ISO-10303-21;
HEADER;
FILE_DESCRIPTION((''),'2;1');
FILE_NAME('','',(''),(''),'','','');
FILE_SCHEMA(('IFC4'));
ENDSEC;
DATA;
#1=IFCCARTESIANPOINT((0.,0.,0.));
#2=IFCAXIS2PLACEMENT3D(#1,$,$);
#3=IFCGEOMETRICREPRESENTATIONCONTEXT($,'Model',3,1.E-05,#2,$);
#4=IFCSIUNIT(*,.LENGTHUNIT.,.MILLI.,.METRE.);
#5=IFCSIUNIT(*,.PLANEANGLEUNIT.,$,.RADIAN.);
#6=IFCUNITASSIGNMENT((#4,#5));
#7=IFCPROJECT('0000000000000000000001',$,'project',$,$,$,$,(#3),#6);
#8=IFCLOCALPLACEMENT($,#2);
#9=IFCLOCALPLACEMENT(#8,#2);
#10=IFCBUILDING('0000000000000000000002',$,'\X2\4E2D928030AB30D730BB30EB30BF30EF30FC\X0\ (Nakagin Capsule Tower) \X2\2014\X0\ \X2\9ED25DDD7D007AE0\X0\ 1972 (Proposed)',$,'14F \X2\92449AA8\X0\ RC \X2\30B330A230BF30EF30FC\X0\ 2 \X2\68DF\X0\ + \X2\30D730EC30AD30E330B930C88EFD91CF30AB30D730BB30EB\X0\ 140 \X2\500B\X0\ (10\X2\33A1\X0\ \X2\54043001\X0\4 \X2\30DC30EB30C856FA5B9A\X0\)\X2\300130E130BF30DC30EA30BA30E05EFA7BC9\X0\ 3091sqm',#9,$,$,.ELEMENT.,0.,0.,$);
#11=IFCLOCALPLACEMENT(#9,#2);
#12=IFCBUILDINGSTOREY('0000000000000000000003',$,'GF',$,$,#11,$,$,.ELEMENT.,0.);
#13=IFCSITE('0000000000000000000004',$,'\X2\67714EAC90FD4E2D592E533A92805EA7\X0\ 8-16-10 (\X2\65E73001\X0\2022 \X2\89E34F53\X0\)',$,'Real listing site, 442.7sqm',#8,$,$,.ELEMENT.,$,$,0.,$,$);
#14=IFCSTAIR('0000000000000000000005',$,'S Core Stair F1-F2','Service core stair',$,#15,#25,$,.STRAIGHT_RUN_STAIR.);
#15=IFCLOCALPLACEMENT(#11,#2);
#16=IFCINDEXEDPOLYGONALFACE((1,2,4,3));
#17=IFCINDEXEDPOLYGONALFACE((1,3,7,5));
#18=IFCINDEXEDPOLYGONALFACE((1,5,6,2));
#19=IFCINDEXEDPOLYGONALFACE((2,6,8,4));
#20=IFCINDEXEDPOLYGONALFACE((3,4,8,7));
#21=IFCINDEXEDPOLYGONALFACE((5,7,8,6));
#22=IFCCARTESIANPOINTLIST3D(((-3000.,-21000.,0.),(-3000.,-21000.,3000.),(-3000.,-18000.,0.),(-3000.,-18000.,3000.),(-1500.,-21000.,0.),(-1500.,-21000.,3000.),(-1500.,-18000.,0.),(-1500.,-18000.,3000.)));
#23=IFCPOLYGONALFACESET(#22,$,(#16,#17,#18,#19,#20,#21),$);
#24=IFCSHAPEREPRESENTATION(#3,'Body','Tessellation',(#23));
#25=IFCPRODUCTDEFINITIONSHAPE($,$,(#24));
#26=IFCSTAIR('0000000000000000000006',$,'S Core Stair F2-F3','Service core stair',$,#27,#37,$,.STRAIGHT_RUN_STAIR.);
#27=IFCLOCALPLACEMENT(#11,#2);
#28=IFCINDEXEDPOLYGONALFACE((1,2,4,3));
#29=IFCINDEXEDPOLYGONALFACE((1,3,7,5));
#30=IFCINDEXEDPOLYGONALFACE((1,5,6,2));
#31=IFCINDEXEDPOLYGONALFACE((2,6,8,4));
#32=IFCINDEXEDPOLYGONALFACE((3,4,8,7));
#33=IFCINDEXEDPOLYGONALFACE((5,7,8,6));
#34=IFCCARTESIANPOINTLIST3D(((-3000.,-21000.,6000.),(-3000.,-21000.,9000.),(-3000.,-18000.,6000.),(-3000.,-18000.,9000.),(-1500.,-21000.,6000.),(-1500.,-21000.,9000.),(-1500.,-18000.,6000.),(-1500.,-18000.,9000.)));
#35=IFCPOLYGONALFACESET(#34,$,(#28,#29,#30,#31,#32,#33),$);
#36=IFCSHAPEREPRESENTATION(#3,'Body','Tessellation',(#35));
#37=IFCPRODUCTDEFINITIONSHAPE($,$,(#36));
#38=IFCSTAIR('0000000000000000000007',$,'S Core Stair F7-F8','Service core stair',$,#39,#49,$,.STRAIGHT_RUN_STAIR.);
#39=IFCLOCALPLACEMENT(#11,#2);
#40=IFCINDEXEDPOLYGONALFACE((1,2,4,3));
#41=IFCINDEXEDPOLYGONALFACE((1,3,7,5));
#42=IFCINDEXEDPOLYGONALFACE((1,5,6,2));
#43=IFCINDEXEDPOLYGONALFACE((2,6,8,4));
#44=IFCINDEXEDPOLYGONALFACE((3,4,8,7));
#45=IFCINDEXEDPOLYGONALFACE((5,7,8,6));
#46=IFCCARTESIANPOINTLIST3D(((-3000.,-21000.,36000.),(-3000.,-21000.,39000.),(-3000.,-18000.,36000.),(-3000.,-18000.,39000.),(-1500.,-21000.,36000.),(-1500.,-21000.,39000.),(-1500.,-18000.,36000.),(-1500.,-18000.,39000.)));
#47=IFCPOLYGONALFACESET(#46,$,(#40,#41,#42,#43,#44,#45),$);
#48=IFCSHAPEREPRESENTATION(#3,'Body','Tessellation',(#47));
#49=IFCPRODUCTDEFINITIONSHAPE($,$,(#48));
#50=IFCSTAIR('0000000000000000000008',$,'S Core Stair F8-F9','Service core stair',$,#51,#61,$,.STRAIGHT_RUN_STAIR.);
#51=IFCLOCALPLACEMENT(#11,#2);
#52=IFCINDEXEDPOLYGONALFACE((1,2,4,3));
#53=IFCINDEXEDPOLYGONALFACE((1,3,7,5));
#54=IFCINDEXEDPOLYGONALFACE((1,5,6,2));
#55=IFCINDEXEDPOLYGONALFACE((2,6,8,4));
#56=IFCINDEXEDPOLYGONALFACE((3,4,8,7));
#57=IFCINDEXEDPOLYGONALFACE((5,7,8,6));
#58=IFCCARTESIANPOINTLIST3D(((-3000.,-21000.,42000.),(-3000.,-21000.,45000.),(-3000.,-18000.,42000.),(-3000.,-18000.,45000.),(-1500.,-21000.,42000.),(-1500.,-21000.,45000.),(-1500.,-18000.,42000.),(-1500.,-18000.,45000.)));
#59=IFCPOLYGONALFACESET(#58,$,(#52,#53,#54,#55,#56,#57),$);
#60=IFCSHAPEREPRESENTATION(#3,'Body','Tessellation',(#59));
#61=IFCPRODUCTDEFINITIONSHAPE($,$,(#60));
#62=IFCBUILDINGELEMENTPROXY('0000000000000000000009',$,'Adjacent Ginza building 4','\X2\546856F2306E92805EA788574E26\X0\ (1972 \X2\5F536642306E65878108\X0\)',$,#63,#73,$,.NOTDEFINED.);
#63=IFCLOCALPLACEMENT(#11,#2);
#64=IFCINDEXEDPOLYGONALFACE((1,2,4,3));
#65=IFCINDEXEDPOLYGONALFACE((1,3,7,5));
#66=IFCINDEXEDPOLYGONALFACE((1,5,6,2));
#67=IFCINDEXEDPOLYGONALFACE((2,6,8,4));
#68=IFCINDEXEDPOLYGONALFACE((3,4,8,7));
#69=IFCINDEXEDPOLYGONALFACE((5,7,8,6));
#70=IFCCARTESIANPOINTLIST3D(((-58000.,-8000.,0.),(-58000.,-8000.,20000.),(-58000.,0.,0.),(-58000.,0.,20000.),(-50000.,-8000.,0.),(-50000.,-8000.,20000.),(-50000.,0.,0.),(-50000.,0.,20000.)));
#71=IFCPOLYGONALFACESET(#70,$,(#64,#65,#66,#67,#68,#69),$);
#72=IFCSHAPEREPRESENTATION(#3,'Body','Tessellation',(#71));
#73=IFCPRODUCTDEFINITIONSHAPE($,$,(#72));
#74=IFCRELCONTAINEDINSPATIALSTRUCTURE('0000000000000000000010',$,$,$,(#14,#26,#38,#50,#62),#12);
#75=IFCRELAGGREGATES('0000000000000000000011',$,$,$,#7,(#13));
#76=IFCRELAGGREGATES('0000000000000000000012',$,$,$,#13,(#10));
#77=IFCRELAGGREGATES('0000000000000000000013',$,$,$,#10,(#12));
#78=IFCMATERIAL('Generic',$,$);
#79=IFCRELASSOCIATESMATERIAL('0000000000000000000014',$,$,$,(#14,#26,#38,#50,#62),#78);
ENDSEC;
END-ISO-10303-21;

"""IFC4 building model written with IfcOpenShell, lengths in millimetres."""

from ifc_helpers import new_model, si_unit, frame, frame_2d, origin, place, context, project, spatial, rectangle, extrude, material, element, save


model = new_model("IFC4")

# Units and contexts
model_context = context("Model", 3, precision=1e-05, world=origin())
ifc_project = project(units=[si_unit("LENGTHUNIT", "METRE", prefix="MILLI"), si_unit("PLANEANGLEUNIT", "RADIAN")], contexts=[model_context])

# Site, building, storey
site_placement = place(None, origin())
site = spatial("IfcSite", under=ifc_project, at=site_placement, Name="東京都中央区銀座 8-16-10 (旧、2022 解体)", ObjectType="Real listing site, 442.7sqm", CompositionType="ELEMENT", RefElevation=0.0)
building_placement = place(site_placement, origin())
building = spatial("IfcBuilding", under=site, at=building_placement, Name="中銀カプセルタワー (Nakagin Capsule Tower) — 黒川紀章 1972 (Proposed)", ObjectType="14F 鉄骨 RC コアタワー 2 棟 + プレキャスト軽量カプセル 140 個 (10㎡ 各、4 ボルト固定)、メタボリズム建築 3091sqm", CompositionType="ELEMENT", ElevationOfRefHeight=0.0, ElevationOfTerrain=0.0)
storey_placement = place(building_placement, origin())
storey = spatial("IfcBuildingStorey", under=building, at=storey_placement, Name="GF", CompositionType="ELEMENT", Elevation=0.0)

# Stairs
ifc_material_1 = material(Name="Generic")
stair_1_placement = place(storey_placement, frame((-1500.0, -10500.0, 0.0)))
element("IfcStair", 1, at=stair_1_placement, inside=storey, material=ifc_material_1, Name="S Core Stair F1-F2", Description="Service core stair", PredefinedType="STRAIGHT_RUN_STAIR", context=model_context, shape_type="SweptSolid", body=[
    extrude(rectangle(XDim=1500.0, YDim=3000.0, at=frame_2d((750.0, 1500.0))), frame((-1500.0, -10500.0, 0.0)), (0.0, 0.0, 1.0), 3000.0),
])
stair_2_placement = place(storey_placement, frame((-1500.0, -10500.0, 3000.0)))
element("IfcStair", 2, at=stair_2_placement, inside=storey, material=ifc_material_1, Name="S Core Stair F2-F3", Description="Service core stair", PredefinedType="STRAIGHT_RUN_STAIR", context=model_context, shape_type="SweptSolid", body=[
    extrude(rectangle(XDim=1500.0, YDim=3000.0, at=frame_2d((750.0, 1500.0))), frame((-1500.0, -10500.0, 3000.0)), (0.0, 0.0, 1.0), 3000.0),
])
stair_3_placement = place(storey_placement, frame((-1500.0, -10500.0, 18000.0)))
element("IfcStair", 3, at=stair_3_placement, inside=storey, material=ifc_material_1, Name="S Core Stair F7-F8", Description="Service core stair", PredefinedType="STRAIGHT_RUN_STAIR", context=model_context, shape_type="SweptSolid", body=[
    extrude(rectangle(XDim=1500.0, YDim=3000.0, at=frame_2d((750.0, 1500.0))), frame((-1500.0, -10500.0, 18000.0)), (0.0, 0.0, 1.0), 3000.0),
])
stair_4_placement = place(storey_placement, frame((-1500.0, -10500.0, 21000.0)))
element("IfcStair", 4, at=stair_4_placement, inside=storey, material=ifc_material_1, Name="S Core Stair F8-F9", Description="Service core stair", PredefinedType="STRAIGHT_RUN_STAIR", context=model_context, shape_type="SweptSolid", body=[
    extrude(rectangle(XDim=1500.0, YDim=3000.0, at=frame_2d((750.0, 1500.0))), frame((-1500.0, -10500.0, 21000.0)), (0.0, 0.0, 1.0), 3000.0),
])

# Building element proxy
proxy_1_placement = place(storey_placement, frame((-29000.0, -4000.0, 0.0)))
element("IfcBuildingElementProxy", 5, at=proxy_1_placement, inside=storey, material=ifc_material_1, Name="Adjacent Ginza building 4", Description="周囲の銀座街並 (1972 当時の文脈)", PredefinedType="NOTDEFINED", context=model_context, shape_type="SweptSolid", body=[
    extrude(rectangle(XDim=8000.0, YDim=8000.0, at=frame_2d((4000.0, 4000.0))), frame((-29000.0, -4000.0, 0.0)), (0.0, 0.0, 1.0), 20000.0),
])

save(model, "model.ifc")
